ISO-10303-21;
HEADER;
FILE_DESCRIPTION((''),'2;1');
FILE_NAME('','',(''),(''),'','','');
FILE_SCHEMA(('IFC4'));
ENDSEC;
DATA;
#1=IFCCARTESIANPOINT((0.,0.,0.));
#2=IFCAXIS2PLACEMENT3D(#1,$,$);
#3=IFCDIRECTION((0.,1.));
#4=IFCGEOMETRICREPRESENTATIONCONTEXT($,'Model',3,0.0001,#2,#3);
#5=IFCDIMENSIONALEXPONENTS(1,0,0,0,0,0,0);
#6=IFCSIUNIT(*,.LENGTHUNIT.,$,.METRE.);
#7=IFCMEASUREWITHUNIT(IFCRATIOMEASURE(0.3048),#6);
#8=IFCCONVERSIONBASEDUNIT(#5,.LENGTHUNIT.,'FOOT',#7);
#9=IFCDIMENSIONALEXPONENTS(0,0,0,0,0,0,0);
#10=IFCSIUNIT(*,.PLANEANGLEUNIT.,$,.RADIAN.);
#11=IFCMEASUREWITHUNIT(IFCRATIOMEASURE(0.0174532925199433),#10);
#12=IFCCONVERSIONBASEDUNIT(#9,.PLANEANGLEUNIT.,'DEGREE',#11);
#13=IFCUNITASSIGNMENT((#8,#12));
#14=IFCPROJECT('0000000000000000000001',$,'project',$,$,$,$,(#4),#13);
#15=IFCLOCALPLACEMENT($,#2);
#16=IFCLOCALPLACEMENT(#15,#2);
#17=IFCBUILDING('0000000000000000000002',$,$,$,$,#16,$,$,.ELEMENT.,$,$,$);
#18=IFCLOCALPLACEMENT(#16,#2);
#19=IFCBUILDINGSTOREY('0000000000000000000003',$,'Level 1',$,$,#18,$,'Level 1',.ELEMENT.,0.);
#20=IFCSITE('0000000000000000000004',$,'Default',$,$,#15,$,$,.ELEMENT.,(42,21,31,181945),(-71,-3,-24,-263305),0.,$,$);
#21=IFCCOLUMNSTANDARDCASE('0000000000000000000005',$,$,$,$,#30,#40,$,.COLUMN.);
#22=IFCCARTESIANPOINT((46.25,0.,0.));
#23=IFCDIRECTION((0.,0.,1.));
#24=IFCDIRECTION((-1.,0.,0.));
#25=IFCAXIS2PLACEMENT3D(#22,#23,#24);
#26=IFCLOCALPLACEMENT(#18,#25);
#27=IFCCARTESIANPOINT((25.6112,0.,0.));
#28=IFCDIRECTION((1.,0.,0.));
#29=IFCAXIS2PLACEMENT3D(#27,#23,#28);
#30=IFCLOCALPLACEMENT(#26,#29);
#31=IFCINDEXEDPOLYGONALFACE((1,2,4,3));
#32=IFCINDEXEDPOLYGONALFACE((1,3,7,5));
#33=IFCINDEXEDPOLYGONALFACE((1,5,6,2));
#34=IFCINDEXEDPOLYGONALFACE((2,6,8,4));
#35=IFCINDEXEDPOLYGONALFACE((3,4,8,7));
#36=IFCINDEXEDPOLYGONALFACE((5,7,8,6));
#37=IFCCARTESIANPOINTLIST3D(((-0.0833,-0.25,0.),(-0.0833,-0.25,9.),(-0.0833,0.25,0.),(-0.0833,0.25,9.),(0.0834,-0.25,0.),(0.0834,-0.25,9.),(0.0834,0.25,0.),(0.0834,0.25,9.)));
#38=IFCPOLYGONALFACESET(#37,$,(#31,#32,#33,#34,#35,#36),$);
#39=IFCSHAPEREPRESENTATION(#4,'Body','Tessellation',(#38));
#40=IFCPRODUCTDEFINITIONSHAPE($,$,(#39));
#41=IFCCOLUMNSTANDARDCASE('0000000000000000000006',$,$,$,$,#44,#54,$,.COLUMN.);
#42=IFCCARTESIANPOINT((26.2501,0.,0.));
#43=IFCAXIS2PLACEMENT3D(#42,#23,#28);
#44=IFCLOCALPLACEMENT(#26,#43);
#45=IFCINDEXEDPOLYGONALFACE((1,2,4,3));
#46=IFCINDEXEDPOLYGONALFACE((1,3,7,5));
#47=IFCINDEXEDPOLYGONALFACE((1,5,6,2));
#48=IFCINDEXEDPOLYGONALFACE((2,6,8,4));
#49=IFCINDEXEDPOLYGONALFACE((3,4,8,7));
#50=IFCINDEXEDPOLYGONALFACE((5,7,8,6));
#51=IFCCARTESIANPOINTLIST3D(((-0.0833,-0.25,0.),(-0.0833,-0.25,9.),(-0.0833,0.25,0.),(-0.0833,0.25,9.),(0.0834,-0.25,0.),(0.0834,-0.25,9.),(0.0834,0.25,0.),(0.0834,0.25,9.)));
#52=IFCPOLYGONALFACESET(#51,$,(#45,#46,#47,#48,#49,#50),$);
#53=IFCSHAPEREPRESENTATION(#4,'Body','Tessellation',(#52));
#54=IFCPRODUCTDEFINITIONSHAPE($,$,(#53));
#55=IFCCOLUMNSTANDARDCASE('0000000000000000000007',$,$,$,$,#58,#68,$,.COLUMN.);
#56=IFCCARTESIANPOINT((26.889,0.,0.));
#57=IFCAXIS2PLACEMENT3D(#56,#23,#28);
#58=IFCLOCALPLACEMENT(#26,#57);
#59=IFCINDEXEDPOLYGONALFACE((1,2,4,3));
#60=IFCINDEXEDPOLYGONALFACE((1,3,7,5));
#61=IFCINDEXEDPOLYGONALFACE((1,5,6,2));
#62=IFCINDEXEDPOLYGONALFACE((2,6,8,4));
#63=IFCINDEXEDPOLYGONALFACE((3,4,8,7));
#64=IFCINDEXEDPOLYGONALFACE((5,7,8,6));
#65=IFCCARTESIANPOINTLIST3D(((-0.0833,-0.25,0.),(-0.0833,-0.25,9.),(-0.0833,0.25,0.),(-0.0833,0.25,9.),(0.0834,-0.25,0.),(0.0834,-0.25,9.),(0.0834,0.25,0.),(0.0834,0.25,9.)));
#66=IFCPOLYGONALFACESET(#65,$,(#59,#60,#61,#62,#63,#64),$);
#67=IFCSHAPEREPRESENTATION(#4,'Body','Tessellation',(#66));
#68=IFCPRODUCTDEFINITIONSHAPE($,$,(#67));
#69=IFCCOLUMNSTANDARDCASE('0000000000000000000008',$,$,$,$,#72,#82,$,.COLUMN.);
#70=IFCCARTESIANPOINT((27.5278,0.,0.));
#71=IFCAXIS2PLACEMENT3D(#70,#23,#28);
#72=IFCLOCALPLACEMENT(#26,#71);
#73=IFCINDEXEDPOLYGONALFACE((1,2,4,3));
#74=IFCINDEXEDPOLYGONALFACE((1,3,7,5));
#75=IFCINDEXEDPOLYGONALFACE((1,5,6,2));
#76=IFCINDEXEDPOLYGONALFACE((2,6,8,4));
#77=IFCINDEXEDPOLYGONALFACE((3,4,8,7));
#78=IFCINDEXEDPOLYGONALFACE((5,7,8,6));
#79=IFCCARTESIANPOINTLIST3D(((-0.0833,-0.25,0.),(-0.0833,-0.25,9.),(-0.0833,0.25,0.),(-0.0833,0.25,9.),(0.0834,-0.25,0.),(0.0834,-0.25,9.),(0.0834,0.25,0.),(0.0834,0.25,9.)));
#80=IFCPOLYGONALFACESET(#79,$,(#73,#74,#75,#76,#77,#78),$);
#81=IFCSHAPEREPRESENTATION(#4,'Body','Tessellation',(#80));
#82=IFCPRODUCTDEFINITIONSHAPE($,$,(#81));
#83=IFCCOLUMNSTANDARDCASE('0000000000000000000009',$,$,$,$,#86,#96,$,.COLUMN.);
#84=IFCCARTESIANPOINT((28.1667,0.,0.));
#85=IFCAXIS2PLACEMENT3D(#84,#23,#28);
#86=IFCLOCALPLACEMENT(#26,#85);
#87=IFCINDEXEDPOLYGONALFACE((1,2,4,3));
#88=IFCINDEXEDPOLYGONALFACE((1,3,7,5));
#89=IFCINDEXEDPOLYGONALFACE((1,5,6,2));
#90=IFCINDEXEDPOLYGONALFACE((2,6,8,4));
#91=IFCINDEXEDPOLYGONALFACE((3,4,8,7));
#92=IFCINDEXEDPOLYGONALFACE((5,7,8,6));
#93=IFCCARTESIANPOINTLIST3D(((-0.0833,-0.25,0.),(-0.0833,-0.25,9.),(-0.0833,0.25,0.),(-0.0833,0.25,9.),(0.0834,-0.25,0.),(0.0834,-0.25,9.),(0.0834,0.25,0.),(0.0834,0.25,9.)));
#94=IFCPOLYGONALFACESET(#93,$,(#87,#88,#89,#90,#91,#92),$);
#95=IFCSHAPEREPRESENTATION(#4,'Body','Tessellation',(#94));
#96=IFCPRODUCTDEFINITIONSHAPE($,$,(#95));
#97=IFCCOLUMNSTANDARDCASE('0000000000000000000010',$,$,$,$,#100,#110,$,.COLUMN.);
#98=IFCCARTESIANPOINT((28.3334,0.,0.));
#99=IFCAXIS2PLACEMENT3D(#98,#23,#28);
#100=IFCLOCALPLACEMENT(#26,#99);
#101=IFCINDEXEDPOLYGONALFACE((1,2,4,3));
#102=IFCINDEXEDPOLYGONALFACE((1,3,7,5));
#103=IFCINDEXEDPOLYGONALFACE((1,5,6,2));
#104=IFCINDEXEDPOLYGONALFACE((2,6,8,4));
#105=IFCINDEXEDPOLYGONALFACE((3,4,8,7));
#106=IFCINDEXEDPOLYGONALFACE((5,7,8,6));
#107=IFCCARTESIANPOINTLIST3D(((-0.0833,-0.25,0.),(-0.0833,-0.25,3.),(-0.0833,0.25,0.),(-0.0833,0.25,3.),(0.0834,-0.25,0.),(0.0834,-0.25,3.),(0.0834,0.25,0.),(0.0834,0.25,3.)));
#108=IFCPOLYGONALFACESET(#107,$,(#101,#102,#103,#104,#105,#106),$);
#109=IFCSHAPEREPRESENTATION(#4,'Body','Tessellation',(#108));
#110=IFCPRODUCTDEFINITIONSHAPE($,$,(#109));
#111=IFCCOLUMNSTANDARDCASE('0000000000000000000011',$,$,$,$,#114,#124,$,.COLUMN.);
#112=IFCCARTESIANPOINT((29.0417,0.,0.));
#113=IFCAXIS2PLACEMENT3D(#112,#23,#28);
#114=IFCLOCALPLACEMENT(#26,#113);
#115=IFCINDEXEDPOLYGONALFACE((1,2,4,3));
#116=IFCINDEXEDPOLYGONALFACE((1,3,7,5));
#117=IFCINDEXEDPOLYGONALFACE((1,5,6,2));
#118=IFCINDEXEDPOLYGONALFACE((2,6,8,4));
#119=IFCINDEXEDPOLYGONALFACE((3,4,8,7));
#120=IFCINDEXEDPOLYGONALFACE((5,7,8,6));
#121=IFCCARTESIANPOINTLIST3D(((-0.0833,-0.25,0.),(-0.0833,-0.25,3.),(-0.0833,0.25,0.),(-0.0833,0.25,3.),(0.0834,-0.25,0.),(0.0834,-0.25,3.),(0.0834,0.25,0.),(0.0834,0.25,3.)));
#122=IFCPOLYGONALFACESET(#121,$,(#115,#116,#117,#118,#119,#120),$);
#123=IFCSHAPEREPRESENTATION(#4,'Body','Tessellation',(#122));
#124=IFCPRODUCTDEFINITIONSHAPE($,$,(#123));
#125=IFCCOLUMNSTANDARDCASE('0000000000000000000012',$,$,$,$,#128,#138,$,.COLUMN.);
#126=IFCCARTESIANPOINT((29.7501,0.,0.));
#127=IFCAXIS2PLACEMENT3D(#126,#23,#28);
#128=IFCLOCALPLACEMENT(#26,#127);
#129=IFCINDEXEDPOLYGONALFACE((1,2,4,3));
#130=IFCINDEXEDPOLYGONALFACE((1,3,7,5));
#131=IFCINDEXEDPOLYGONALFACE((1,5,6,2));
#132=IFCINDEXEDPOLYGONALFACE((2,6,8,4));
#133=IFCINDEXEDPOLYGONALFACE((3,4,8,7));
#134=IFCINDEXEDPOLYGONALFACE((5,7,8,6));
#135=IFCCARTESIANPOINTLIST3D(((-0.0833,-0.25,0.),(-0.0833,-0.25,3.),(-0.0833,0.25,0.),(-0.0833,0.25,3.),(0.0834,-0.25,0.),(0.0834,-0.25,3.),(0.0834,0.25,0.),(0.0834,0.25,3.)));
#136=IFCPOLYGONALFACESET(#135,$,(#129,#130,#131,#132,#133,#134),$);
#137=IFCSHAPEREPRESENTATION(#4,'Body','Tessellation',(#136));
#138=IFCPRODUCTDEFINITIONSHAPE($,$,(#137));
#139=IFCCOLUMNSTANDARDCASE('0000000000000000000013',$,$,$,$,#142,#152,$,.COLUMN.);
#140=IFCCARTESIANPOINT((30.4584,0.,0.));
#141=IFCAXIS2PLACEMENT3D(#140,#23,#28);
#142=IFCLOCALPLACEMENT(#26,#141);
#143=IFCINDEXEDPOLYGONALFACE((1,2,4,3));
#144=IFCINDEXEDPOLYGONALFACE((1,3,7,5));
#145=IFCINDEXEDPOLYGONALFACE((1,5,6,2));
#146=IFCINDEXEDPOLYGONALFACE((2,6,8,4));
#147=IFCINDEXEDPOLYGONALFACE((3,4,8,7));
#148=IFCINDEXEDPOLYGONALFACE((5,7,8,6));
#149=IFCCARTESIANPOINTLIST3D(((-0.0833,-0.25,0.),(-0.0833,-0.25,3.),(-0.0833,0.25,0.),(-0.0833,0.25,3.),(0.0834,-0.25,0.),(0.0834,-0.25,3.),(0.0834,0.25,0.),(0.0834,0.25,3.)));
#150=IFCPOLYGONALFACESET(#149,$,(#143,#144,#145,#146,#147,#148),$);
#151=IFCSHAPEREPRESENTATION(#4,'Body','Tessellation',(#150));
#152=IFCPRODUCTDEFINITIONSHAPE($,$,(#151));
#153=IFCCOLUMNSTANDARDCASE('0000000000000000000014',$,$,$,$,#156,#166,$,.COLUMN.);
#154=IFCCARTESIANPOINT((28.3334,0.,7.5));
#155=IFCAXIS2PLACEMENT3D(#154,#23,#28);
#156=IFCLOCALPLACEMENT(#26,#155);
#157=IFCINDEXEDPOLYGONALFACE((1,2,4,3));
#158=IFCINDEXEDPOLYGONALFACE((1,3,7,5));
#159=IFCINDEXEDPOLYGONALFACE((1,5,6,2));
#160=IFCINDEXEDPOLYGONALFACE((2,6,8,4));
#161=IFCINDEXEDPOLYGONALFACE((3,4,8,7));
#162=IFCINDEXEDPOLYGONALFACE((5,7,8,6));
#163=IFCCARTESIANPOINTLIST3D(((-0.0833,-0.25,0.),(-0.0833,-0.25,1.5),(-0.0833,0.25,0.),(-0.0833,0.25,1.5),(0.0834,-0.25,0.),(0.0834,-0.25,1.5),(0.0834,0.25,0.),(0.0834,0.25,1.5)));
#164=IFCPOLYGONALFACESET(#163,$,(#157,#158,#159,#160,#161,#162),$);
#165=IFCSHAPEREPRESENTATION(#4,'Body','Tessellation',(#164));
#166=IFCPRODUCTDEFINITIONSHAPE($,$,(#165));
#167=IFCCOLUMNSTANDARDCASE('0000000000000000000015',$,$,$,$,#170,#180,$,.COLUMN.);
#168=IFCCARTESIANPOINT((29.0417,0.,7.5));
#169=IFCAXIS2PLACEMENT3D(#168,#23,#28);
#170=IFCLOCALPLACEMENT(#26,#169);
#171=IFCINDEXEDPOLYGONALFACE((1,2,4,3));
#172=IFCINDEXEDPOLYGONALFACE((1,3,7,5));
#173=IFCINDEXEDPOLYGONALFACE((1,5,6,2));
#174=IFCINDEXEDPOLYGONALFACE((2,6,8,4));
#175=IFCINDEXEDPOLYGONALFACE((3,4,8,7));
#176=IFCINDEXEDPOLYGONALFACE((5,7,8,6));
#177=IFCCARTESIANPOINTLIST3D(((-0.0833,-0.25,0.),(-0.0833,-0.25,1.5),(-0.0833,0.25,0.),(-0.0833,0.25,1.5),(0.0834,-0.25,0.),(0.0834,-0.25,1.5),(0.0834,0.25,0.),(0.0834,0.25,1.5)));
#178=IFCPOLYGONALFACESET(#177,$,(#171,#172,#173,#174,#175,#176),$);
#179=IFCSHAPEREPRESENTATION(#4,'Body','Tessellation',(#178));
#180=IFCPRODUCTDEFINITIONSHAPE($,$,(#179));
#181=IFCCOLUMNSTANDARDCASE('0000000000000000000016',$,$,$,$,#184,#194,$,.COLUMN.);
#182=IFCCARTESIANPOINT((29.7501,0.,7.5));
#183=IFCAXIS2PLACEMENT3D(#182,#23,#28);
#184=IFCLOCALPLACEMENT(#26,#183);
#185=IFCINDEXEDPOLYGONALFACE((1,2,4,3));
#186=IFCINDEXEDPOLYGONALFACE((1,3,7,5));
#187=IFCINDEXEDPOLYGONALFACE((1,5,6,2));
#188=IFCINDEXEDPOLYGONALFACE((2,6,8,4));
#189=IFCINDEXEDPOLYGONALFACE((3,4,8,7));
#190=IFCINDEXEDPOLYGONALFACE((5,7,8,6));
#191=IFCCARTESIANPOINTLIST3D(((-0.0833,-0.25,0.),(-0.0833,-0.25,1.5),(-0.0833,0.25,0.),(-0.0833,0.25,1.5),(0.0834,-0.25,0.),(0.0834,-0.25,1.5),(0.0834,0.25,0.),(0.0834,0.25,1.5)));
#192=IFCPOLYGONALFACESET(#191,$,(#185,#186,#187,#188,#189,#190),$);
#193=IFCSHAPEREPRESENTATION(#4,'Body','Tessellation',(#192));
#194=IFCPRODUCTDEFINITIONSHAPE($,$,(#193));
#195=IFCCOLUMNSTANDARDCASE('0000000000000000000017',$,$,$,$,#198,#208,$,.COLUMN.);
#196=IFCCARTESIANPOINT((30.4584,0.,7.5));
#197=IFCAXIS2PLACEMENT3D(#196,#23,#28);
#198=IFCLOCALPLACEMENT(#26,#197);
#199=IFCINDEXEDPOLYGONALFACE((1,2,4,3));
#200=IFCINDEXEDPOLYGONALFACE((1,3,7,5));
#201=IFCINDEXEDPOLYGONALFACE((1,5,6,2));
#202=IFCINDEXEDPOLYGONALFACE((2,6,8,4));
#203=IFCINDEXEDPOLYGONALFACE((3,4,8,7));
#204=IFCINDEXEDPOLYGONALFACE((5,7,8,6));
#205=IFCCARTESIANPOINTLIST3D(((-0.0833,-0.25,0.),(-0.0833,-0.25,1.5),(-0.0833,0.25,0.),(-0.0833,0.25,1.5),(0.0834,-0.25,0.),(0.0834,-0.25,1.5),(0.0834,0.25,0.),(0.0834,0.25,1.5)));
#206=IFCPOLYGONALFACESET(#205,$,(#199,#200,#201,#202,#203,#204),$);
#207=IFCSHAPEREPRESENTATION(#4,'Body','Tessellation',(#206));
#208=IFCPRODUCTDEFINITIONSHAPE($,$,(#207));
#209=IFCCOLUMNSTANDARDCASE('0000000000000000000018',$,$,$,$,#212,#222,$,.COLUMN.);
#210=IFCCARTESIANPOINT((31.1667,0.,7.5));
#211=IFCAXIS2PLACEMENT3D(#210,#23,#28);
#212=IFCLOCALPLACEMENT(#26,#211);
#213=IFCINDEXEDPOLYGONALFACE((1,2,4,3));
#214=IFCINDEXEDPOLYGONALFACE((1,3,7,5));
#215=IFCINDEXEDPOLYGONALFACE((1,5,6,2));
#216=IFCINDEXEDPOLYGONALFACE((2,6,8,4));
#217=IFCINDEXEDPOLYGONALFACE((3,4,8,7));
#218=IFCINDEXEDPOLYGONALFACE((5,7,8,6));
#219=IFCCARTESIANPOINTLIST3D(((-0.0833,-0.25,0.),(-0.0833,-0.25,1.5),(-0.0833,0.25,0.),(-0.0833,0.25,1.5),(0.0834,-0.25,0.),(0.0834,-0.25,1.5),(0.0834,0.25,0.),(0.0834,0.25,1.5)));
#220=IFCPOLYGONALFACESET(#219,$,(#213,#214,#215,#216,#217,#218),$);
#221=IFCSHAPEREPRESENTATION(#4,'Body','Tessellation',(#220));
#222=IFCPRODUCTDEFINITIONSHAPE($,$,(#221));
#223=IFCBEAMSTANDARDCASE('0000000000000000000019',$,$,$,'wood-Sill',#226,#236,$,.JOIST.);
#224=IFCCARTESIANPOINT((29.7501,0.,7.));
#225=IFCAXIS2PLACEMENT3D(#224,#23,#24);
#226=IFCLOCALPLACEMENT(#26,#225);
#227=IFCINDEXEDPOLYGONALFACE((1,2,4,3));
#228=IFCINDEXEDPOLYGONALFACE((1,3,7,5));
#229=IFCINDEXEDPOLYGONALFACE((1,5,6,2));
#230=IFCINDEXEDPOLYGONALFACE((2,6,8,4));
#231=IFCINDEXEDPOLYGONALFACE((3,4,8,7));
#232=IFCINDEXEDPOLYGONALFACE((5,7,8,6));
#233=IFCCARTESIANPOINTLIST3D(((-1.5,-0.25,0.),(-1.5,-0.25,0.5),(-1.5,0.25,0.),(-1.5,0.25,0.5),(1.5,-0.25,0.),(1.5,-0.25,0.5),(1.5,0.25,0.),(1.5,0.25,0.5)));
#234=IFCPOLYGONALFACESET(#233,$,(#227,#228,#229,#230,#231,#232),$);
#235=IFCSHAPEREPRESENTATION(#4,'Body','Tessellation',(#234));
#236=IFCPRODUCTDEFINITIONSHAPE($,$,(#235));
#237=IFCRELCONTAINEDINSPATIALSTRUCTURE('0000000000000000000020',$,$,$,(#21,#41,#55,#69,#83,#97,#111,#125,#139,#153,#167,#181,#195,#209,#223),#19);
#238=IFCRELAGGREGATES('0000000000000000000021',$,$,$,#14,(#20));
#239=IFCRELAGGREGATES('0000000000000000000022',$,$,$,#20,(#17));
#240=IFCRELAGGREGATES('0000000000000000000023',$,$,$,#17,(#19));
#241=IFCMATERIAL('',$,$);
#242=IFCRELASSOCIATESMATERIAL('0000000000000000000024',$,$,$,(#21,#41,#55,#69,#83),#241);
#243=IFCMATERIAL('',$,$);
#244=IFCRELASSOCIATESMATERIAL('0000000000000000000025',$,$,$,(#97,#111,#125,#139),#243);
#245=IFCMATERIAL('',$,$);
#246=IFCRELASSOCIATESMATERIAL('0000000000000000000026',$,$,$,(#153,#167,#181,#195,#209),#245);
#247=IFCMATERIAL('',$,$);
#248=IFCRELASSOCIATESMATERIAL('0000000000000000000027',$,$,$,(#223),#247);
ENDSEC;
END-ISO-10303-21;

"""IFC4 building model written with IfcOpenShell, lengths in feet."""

from ifc_helpers import new_model, entity, si_unit, converted_unit, direction, frame, origin, place, context, project, spatial, rectangle, extrude, material, element, save


model = new_model("IFC4")

# Units and contexts
model_context = context("Model", 3, precision=0.0001, world=origin(), true_north=direction((0.0, 1.0)))
ifc_project = project(units=[converted_unit("LENGTHUNIT", "FOOT", entity("IfcRatioMeasure", 0.3048), si_unit("LENGTHUNIT", "METRE"), dimensions=[1, 0, 0, 0, 0, 0, 0]), converted_unit("PLANEANGLEUNIT", "DEGREE", entity("IfcRatioMeasure", 0.0174532925199433), si_unit("PLANEANGLEUNIT", "RADIAN"), dimensions=[0, 0, 0, 0, 0, 0, 0])], contexts=[model_context])

# Site, building, storey
site_placement = place(None, origin())
site = spatial("IfcSite", under=ifc_project, at=site_placement, Name="Default", CompositionType="ELEMENT", RefLatitude=(42, 21, 31, 181945), RefLongitude=(-71, -3, -24, -263305), RefElevation=0.0)
building_placement = place(site_placement, origin())
building = spatial("IfcBuilding", under=site, at=building_placement, CompositionType="ELEMENT")
storey_placement = place(building_placement, origin())
storey = spatial("IfcBuildingStorey", under=building, at=storey_placement, Name="Level 1", LongName="Level 1", CompositionType="ELEMENT", Elevation=0.0)

# Columns
ifc_material_1 = material(Name="")
placement = place(storey_placement, frame((46.25, 0.0, 0.0), z_axis=(0.0, 0.0, 1.0), x_axis=(-1.0, 0.0, 0.0)))
for number, where, z_axis, x_axis in (
    (1, (25.6112, 0.0, 0.0), (0.0, 0.0, 1.0), (1.0, 0.0, 0.0)),
    (2, (26.2501, 0.0, 0.0), (0.0, 0.0, 1.0), (1.0, 0.0, 0.0)),
    (3, (26.889, 0.0, 0.0), (0.0, 0.0, 1.0), (1.0, 0.0, 0.0)),
    (4, (27.5278, 0.0, 0.0), (0.0, 0.0, 1.0), (1.0, 0.0, 0.0)),
    (5, (28.1667, 0.0, 0.0), (0.0, 0.0, 1.0), (1.0, 0.0, 0.0)),
):
    element("IfcColumnStandardCase", number, at=place(placement, frame(where, z_axis=z_axis, x_axis=x_axis)), inside=storey, material=ifc_material_1, PredefinedType="COLUMN", context=model_context, shape_type="SweptSolid", body=[
        extrude(rectangle(XDim=0.1667, YDim=0.5), origin(), (0.0, 0.0, 1.0), 9.0),
    ])
ifc_material_2 = material(Name="")
for number, where, z_axis, x_axis in (
    (6, (28.3334, 0.0, 0.0), (0.0, 0.0, 1.0), (1.0, 0.0, 0.0)),
    (7, (29.0417, 0.0, 0.0), (0.0, 0.0, 1.0), (1.0, 0.0, 0.0)),
    (8, (29.7501, 0.0, 0.0), (0.0, 0.0, 1.0), (1.0, 0.0, 0.0)),
    (9, (30.4584, 0.0, 0.0), (0.0, 0.0, 1.0), (1.0, 0.0, 0.0)),
):
    element("IfcColumnStandardCase", number, at=place(placement, frame(where, z_axis=z_axis, x_axis=x_axis)), inside=storey, material=ifc_material_2, PredefinedType="COLUMN", context=model_context, shape_type="SweptSolid", body=[
        extrude(rectangle(XDim=0.1667, YDim=0.5), origin(), (0.0, 0.0, 1.0), 3.0),
    ])
ifc_material_3 = material(Name="")
for number, where, z_axis, x_axis in (
    (10, (28.3334, 0.0, 7.5), (0.0, 0.0, 1.0), (1.0, 0.0, 0.0)),
    (11, (29.0417, 0.0, 7.5), (0.0, 0.0, 1.0), (1.0, 0.0, 0.0)),
    (12, (29.7501, 0.0, 7.5), (0.0, 0.0, 1.0), (1.0, 0.0, 0.0)),
    (13, (30.4584, 0.0, 7.5), (0.0, 0.0, 1.0), (1.0, 0.0, 0.0)),
    (14, (31.1667, 0.0, 7.5), (0.0, 0.0, 1.0), (1.0, 0.0, 0.0)),
):
    element("IfcColumnStandardCase", number, at=place(placement, frame(where, z_axis=z_axis, x_axis=x_axis)), inside=storey, material=ifc_material_3, PredefinedType="COLUMN", context=model_context, shape_type="SweptSolid", body=[
        extrude(rectangle(XDim=0.1667, YDim=0.5), origin(), (0.0, 0.0, 1.0), 1.5),
    ])

# Beam
ifc_material_4 = material(Name="")
for number, where, z_axis, x_axis in (
    (15, (29.7501, 0.0, 7.0), (0.0, 0.0, 1.0), (-1.0, 0.0, 0.0)),
):
    element("IfcBeamStandardCase", number, at=place(placement, frame(where, z_axis=z_axis, x_axis=x_axis)), inside=storey, material=ifc_material_4, ObjectType="wood-Sill", PredefinedType="JOIST", context=model_context, shape_type="SweptSolid", body=[
        extrude(rectangle(XDim=3.0, YDim=0.5), origin(), (0.0, 0.0, 1.0), 0.5),
    ])

save(model, "model.ifc")
